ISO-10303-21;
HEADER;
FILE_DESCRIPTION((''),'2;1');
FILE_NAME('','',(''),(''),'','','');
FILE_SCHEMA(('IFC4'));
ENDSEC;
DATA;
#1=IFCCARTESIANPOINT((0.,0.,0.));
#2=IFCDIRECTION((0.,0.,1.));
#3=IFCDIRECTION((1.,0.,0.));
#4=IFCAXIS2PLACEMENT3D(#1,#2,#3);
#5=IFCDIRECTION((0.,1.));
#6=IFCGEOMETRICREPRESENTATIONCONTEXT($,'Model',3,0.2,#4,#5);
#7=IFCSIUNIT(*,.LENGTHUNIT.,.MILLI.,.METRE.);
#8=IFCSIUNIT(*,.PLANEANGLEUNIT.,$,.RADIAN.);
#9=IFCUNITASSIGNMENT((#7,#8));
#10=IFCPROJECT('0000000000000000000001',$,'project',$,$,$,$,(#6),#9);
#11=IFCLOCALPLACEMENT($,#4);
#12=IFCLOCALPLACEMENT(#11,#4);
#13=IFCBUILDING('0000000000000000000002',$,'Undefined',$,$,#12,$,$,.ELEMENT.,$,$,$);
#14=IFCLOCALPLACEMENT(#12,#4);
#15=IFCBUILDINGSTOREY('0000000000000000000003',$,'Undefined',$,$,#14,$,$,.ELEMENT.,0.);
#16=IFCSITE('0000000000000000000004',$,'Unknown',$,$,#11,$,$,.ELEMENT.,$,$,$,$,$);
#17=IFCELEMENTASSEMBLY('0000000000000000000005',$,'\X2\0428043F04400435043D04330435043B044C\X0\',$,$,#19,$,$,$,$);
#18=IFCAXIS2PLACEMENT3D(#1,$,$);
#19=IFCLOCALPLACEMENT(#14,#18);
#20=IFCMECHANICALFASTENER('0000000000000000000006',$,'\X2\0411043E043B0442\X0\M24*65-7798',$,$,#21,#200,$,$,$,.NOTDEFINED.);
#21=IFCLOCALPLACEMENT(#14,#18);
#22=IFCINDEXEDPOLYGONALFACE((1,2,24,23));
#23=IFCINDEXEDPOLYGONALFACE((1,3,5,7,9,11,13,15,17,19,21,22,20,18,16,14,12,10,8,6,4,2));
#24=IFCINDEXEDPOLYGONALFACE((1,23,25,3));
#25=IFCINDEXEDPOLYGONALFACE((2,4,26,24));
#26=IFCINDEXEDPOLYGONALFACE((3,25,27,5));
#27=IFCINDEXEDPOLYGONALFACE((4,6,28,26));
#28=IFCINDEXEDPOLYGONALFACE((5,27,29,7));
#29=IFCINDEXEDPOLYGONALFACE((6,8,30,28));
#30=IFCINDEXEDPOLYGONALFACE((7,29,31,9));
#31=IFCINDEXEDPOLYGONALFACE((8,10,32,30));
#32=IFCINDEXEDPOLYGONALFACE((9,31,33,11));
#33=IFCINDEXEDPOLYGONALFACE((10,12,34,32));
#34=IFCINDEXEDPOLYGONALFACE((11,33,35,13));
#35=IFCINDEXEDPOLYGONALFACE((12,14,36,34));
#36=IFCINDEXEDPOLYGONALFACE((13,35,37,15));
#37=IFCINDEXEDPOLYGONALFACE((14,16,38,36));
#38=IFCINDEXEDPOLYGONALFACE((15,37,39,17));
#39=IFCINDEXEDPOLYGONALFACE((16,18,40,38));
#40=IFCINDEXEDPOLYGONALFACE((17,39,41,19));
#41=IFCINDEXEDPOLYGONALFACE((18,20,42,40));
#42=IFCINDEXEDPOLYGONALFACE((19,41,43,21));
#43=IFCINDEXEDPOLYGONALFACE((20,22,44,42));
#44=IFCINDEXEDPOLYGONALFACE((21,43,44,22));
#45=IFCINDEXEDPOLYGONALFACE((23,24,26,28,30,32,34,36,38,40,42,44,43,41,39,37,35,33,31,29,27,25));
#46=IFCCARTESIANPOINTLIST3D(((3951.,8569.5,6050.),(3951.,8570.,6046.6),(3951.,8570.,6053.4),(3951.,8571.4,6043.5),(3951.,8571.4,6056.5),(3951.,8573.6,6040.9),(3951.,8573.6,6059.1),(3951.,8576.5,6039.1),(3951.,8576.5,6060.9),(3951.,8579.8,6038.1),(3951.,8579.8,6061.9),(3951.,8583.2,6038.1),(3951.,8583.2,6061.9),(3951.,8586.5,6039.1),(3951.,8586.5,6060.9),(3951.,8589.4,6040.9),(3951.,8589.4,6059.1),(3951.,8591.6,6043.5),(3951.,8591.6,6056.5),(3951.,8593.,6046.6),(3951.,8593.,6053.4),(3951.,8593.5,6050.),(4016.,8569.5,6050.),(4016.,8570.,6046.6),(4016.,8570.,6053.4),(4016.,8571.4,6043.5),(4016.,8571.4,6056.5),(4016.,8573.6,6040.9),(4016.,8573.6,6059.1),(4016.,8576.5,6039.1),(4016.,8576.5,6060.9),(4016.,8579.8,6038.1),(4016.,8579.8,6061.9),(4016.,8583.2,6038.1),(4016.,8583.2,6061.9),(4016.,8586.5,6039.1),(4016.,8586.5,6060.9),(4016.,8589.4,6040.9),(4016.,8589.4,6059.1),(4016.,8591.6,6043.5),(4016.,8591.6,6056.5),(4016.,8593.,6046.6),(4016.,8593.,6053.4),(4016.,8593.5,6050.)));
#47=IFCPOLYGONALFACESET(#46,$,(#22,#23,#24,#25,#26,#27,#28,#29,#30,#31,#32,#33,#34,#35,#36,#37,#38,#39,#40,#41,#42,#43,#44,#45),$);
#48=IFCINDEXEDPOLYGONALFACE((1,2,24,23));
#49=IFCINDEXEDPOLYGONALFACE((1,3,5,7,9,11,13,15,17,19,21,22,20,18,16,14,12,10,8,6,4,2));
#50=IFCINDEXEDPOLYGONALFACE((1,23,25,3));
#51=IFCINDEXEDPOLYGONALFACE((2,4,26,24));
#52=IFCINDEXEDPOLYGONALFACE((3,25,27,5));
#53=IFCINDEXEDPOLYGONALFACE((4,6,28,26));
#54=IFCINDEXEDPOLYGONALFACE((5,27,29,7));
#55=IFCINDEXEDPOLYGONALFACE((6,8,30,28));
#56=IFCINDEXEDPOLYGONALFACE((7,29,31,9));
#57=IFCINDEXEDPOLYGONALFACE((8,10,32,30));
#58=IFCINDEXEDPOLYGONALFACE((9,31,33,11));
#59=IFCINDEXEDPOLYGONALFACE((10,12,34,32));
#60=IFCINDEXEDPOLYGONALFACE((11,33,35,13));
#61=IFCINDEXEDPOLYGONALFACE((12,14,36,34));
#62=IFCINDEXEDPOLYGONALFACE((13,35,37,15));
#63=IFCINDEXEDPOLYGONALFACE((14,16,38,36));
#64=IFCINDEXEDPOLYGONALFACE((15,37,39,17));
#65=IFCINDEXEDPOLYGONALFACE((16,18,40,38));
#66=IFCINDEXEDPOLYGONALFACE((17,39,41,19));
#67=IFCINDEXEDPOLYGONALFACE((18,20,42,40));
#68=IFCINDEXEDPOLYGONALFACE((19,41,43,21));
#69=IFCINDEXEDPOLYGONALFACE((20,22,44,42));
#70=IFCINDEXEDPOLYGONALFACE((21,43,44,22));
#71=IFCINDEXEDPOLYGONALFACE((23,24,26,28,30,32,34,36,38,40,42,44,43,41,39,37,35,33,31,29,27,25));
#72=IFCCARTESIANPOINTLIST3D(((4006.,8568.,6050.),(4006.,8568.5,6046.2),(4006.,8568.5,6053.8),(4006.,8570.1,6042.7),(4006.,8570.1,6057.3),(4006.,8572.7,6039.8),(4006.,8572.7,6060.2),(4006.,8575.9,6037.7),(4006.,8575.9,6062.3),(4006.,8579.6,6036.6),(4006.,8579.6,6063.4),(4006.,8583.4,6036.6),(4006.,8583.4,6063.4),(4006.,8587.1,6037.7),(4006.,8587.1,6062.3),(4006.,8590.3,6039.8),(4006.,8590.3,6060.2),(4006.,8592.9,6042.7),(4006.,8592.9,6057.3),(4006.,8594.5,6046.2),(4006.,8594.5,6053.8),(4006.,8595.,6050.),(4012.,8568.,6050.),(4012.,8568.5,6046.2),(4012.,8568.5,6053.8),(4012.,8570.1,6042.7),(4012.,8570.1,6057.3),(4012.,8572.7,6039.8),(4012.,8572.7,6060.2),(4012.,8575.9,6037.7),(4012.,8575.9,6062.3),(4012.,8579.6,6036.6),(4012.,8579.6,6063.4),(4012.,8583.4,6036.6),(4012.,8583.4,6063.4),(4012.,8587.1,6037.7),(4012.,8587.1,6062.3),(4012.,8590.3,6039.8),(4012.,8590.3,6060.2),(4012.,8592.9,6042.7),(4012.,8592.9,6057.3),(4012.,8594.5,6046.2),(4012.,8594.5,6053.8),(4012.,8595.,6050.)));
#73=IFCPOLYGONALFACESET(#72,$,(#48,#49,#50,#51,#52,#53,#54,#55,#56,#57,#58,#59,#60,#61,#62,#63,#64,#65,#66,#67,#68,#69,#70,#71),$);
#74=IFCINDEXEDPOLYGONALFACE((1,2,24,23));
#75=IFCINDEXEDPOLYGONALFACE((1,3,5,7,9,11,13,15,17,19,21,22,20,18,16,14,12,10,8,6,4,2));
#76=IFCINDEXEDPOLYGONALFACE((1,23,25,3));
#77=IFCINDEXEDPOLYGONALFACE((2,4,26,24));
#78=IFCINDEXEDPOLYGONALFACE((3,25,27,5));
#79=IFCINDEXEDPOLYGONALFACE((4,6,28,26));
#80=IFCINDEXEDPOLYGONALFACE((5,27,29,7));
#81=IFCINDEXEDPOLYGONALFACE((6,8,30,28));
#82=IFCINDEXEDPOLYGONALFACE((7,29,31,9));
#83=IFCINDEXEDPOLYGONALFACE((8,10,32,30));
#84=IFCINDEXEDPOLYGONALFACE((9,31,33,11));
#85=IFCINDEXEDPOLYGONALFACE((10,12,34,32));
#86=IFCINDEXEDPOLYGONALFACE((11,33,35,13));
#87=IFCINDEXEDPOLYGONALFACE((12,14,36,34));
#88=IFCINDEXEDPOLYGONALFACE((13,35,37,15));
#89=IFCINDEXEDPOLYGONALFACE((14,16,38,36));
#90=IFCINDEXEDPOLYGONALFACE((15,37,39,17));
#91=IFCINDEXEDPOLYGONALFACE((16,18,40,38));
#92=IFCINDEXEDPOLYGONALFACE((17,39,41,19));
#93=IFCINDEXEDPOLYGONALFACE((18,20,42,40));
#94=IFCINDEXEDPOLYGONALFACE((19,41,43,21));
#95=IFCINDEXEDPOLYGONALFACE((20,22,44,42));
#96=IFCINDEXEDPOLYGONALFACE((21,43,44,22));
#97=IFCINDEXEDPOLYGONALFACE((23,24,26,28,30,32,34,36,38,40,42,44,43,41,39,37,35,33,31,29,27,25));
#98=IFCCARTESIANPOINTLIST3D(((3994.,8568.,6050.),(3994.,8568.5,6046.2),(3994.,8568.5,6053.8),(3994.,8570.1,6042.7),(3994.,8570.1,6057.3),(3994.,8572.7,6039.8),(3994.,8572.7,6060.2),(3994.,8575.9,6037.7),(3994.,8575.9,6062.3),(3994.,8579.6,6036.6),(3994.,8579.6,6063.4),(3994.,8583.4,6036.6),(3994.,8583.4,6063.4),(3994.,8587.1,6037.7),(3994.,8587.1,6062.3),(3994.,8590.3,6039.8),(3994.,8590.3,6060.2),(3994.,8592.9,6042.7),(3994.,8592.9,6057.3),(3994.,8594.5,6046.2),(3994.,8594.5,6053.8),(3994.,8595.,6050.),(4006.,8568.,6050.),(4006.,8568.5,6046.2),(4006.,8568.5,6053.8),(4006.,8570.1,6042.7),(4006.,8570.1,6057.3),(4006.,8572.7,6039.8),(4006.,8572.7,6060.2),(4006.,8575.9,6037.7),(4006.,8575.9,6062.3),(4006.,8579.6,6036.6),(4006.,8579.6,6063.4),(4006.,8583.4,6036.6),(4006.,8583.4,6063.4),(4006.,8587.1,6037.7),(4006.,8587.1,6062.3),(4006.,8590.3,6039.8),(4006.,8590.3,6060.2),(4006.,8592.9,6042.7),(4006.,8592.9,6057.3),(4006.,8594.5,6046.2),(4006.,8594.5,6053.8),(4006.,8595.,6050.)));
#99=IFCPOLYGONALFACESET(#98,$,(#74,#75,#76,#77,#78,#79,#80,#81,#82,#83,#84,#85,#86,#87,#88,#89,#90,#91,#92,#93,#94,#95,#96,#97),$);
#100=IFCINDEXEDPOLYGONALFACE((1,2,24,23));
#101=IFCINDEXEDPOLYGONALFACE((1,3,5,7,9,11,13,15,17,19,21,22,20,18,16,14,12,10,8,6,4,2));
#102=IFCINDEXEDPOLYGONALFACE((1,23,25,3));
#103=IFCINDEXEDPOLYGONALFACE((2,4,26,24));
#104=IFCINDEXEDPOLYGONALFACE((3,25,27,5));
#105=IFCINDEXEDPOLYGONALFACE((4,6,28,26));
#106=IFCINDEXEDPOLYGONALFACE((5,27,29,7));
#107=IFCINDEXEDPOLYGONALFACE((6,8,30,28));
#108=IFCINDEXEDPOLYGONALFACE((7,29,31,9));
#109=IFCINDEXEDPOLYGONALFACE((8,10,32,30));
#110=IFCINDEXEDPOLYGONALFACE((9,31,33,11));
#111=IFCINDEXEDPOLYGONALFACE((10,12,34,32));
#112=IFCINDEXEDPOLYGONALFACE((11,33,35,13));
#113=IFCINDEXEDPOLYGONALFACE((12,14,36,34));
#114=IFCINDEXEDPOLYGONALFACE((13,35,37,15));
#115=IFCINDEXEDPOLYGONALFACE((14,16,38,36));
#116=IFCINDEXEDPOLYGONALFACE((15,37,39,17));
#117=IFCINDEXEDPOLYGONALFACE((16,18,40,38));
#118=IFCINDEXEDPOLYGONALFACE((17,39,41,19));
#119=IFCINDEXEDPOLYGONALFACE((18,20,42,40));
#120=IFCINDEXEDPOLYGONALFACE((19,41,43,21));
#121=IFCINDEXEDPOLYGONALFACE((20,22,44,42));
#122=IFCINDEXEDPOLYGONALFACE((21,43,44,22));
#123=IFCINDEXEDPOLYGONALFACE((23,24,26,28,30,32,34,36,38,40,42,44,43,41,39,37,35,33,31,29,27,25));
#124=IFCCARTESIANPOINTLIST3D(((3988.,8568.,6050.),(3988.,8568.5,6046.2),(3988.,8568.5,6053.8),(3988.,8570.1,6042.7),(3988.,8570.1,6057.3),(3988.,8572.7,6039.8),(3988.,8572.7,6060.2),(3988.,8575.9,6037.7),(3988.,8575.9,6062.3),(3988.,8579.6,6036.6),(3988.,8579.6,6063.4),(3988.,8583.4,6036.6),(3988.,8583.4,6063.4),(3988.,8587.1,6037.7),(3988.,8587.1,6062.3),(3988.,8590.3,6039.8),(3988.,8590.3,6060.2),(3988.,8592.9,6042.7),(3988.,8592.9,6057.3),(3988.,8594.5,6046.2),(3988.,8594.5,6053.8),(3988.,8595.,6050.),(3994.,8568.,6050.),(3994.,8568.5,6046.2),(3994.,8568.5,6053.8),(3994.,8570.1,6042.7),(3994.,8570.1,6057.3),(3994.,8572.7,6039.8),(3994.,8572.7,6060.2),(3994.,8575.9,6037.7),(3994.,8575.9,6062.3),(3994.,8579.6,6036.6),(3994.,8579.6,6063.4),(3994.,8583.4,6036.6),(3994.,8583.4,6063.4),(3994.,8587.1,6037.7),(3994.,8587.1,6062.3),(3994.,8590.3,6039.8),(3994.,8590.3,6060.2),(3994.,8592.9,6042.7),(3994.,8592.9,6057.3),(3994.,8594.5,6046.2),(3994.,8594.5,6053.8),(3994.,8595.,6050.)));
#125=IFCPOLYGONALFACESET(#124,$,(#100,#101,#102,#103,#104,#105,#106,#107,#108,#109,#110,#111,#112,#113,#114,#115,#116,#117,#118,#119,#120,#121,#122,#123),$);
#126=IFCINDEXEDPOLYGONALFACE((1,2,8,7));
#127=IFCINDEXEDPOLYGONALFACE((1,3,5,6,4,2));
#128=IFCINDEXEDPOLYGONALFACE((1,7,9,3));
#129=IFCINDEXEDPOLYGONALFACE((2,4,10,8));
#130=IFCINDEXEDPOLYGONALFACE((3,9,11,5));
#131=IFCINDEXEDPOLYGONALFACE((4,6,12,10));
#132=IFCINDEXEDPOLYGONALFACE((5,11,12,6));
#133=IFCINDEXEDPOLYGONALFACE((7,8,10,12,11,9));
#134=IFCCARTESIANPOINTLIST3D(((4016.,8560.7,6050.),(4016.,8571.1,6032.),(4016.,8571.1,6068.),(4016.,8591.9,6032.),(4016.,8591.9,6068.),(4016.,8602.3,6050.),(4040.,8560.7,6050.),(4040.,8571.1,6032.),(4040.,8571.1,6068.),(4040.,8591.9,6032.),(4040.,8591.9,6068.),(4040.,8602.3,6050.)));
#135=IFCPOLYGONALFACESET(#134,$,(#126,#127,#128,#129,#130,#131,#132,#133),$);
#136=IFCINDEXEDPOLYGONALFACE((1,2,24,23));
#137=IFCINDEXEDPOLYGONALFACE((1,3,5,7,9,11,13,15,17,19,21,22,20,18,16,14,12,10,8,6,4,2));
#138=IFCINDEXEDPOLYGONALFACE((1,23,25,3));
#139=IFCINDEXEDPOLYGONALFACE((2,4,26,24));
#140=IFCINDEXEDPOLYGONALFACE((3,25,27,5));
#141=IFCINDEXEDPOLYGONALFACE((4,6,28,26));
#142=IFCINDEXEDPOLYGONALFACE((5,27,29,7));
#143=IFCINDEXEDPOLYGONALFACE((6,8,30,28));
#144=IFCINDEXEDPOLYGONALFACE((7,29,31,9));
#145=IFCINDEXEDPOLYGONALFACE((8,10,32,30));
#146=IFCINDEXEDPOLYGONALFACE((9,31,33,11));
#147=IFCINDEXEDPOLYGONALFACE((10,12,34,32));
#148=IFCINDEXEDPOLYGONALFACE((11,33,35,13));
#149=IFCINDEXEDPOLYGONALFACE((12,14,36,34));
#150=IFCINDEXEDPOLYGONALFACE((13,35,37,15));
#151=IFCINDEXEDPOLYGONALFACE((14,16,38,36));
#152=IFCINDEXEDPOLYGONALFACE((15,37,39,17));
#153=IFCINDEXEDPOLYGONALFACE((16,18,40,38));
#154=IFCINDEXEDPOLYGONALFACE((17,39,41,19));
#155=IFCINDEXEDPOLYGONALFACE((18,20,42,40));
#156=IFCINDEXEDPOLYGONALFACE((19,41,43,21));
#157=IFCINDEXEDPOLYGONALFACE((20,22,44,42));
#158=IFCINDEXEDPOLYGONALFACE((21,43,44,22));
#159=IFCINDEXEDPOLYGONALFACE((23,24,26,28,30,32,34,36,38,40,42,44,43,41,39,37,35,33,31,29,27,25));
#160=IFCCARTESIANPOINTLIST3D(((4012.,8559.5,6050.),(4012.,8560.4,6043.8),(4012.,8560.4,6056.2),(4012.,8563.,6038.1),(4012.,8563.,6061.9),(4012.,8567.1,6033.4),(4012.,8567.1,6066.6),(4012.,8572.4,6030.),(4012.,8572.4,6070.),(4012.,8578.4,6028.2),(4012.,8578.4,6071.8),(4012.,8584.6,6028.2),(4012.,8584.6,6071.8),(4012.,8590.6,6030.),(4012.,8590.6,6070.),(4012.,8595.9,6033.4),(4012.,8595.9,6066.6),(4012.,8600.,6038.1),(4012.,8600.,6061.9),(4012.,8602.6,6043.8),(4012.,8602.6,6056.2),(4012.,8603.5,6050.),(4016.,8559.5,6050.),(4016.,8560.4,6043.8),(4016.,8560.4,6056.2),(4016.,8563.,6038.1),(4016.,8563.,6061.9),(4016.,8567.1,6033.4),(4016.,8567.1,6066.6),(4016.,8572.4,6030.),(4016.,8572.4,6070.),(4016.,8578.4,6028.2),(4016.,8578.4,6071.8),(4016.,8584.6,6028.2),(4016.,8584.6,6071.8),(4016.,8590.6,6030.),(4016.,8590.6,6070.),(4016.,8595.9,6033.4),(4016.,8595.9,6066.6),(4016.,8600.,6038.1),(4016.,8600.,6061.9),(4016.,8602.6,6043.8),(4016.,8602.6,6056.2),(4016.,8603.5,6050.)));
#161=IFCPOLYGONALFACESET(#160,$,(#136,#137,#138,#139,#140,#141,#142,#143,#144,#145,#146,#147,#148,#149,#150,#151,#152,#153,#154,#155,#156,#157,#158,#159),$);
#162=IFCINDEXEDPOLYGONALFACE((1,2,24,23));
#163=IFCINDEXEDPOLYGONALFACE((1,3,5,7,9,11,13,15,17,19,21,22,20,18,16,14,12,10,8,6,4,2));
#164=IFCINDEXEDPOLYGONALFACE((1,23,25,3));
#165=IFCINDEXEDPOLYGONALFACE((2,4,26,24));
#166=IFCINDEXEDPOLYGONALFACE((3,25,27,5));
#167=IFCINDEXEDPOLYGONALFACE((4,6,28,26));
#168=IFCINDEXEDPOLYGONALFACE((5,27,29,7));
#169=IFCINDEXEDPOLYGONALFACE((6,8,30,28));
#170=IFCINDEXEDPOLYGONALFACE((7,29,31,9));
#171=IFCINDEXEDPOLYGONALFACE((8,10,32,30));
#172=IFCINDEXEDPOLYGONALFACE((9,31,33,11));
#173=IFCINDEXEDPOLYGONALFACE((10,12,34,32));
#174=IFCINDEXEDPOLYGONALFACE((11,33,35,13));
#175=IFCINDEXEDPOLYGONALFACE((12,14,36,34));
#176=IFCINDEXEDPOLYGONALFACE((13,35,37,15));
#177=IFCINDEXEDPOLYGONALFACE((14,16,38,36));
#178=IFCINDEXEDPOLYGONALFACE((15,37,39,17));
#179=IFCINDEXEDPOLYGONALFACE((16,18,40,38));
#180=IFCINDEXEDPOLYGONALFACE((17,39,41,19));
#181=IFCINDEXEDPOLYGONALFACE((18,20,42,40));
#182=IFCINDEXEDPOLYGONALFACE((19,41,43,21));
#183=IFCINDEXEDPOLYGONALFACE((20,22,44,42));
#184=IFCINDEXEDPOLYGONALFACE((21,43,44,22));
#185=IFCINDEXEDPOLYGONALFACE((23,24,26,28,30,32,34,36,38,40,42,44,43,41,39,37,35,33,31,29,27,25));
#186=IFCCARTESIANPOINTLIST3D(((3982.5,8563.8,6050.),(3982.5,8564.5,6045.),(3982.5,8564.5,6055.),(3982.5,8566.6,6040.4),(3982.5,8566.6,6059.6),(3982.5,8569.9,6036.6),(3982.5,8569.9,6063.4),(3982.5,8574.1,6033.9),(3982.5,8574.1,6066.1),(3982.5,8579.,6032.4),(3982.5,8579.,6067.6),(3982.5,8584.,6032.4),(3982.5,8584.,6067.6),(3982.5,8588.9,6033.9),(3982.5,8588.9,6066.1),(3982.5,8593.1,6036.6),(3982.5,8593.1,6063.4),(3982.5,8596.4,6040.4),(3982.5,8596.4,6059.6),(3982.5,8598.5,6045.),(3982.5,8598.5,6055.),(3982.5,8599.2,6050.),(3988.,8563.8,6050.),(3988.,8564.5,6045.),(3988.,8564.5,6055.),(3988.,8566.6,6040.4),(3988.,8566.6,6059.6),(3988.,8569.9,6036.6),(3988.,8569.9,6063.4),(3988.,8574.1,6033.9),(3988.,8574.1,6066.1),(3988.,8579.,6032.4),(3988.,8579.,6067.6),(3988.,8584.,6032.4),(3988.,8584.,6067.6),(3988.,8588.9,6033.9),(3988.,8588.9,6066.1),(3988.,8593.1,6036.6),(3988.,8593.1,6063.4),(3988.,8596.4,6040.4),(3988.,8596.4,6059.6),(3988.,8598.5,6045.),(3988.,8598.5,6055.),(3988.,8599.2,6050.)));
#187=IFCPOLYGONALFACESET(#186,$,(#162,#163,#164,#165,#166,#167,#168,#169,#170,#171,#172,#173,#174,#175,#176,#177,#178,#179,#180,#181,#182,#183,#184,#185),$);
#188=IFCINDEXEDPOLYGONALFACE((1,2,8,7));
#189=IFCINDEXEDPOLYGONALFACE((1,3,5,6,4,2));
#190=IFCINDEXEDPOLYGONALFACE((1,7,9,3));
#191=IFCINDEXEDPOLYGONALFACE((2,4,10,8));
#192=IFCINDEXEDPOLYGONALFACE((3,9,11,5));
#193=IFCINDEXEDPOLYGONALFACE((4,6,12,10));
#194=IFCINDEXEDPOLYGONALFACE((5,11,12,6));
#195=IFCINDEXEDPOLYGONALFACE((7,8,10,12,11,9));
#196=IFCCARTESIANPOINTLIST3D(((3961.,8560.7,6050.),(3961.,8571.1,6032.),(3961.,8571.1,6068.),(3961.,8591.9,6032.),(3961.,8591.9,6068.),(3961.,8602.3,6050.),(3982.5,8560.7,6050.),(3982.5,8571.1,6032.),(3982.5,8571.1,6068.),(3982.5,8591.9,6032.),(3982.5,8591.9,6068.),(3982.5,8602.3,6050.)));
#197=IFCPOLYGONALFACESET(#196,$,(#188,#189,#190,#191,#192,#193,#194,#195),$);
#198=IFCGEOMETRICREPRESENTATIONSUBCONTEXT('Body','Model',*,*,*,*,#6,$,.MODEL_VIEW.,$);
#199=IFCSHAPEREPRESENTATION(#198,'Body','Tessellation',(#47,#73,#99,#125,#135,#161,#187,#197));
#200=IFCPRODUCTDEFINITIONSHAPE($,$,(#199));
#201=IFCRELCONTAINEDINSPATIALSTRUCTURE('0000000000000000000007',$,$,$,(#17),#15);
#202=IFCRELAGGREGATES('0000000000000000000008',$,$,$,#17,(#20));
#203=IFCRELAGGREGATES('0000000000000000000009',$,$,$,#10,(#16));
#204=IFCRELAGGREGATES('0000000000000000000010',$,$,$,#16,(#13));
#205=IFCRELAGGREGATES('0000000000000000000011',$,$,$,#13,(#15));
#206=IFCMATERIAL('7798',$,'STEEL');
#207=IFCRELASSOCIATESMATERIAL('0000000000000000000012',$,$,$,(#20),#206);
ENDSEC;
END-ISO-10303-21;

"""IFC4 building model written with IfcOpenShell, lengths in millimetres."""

from ifc_helpers import new_model, si_unit, direction, frame, origin_with_axes, place, context, subcontext, project, spatial, line, arc, indexed_curve, outline, extrude, source, transform, mapped, material, element, aggregate, save


model = new_model("IFC4")

# Units and contexts
model_context = context("Model", 3, precision=0.2, world=origin_with_axes(), true_north=direction((0.0, 1.0)))
body_context = subcontext(model_context, "Body", "Model", "MODEL_VIEW")
ifc_project = project(units=[si_unit("LENGTHUNIT", "METRE", prefix="MILLI"), si_unit("PLANEANGLEUNIT", "RADIAN")], contexts=[model_context])

# Site, building, storey
site_placement = place(None, origin_with_axes())
site = spatial("IfcSite", under=ifc_project, at=site_placement, Name="Unknown", CompositionType="ELEMENT")
building_placement = place(site_placement, origin_with_axes())
building = spatial("IfcBuilding", under=site, at=building_placement, Name="Undefined", CompositionType="ELEMENT")
storey_placement = place(building_placement, origin_with_axes())
storey = spatial("IfcBuildingStorey", under=building, at=storey_placement, Name="Undefined", CompositionType="ELEMENT", Elevation=0.0)

# Shared definitions
ifc_material_1 = material(Name="7798", Category="STEEL")

# Element assembly, mechanical fastener
assembly_1_placement = place(storey_placement, frame((3949.0, 5673.0, 6045.0), z_axis=(0.0, 0.0, 1.0), x_axis=(0.0, 1.0, 0.0)))
assembly_1 = element("IfcElementAssembly", 1, at=assembly_1_placement, inside=storey, Name="Шпренгель")
shared_shape_1 = source(origin_with_axes(), body_context, "Body", "SweptSolid", [
    extrude(outline(indexed_curve([(12.0, 0.0), (0.0, 12.0), (-12.0, 0.0), (0.0, -12.0)], segments=[arc(1, 2, 3), arc(3, 4, 1)])), frame((0.0, 0.0, 16.0), z_axis=(0.0, 0.0, -1.0), x_axis=(0.0, 1.0, 0.0)), (0.0, 0.0, 1.0), 65.0),
    extrude(outline(indexed_curve([(13.5, 0.0), (0.0, 13.5), (-13.5, 0.0), (0.0, -13.5)], segments=[arc(1, 2, 3), arc(3, 4, 1)])), frame((0.0, 0.0, 12.0), z_axis=(0.0, 0.0, -1.0), x_axis=(0.0, 1.0, 0.0)), (0.0, 0.0, 1.0), 6.0),
    extrude(outline(indexed_curve([(13.5, 0.0), (0.0, 13.5), (-13.5, 0.0), (0.0, -13.5)], segments=[arc(1, 2, 3), arc(3, 4, 1)])), frame((0.0, 0.0, 6.0), z_axis=(0.0, 0.0, -1.0), x_axis=(0.0, 1.0, 0.0)), (0.0, 0.0, 1.0), 12.0),
    extrude(outline(indexed_curve([(13.5, 0.0), (0.0, 13.5), (-13.5, 0.0), (0.0, -13.5)], segments=[arc(1, 2, 3), arc(3, 4, 1)])), frame((0.0, 0.0, -6.0), z_axis=(0.0, 0.0, -1.0), x_axis=(0.0, 1.0, 0.0)), (0.0, 0.0, 1.0), 6.0),
    extrude(outline(indexed_curve([(20.8, 0.0), (10.4, 18.0), (-10.4, 18.0), (-20.8, 0.0), (-10.4, -18.0), (10.4, -18.0)], segments=[line(1, 2, 3, 4, 5, 6, 1)])), frame((0.0, 0.0, 40.0), z_axis=(0.0, 0.0, -1.0), x_axis=(0.0, 1.0, 0.0)), (0.0, 0.0, 1.0), 24.0),
    extrude(outline(indexed_curve([(22.0, 0.0), (0.0, 22.0), (-22.0, 0.0), (0.0, -22.0)], segments=[arc(1, 2, 3), arc(3, 4, 1)])), frame((0.0, 0.0, 16.0), z_axis=(0.0, 0.0, -1.0), x_axis=(0.0, 1.0, 0.0)), (0.0, 0.0, 1.0), 4.0),
    extrude(outline(indexed_curve([(17.8, 0.0), (0.0, 17.8), (-17.8, 0.0), (0.0, -17.8)], segments=[arc(1, 2, 3), arc(3, 4, 1)])), frame((0.0, 0.0, -12.0), z_axis=(0.0, 0.0, -1.0), x_axis=(0.0, 1.0, 0.0)), (0.0, 0.0, 1.0), 5.5),
    extrude(outline(indexed_curve([(20.8, 0.0), (10.4, 18.0), (-10.4, 18.0), (-20.8, 0.0), (-10.4, -18.0), (10.4, -18.0)], segments=[line(1, 2, 3, 4, 5, 6, 1)])), frame((0.0, 0.0, -17.5), z_axis=(0.0, 0.0, -1.0), x_axis=(0.0, 1.0, 0.0)), (0.0, 0.0, 1.0), 21.5),
])
mechanical_fastener_1_placement = place(assembly_1_placement, frame((2908.5, -51.0, 5.0), z_axis=(0.0, -1.0, 0.0), x_axis=(0.0, 0.0, 1.0)))
mechanical_fastener_1 = element("IfcMechanicalFastener", 2, at=mechanical_fastener_1_placement, material=ifc_material_1, Name="БолтM24*65-7798", PredefinedType="NOTDEFINED", context=body_context, shape_type="MappedRepresentation", body=[
    mapped(shared_shape_1, transform((0.0, 0.0, 0.0))),
])
aggregate(assembly_1, [mechanical_fastener_1])

save(model, "model.ifc")
